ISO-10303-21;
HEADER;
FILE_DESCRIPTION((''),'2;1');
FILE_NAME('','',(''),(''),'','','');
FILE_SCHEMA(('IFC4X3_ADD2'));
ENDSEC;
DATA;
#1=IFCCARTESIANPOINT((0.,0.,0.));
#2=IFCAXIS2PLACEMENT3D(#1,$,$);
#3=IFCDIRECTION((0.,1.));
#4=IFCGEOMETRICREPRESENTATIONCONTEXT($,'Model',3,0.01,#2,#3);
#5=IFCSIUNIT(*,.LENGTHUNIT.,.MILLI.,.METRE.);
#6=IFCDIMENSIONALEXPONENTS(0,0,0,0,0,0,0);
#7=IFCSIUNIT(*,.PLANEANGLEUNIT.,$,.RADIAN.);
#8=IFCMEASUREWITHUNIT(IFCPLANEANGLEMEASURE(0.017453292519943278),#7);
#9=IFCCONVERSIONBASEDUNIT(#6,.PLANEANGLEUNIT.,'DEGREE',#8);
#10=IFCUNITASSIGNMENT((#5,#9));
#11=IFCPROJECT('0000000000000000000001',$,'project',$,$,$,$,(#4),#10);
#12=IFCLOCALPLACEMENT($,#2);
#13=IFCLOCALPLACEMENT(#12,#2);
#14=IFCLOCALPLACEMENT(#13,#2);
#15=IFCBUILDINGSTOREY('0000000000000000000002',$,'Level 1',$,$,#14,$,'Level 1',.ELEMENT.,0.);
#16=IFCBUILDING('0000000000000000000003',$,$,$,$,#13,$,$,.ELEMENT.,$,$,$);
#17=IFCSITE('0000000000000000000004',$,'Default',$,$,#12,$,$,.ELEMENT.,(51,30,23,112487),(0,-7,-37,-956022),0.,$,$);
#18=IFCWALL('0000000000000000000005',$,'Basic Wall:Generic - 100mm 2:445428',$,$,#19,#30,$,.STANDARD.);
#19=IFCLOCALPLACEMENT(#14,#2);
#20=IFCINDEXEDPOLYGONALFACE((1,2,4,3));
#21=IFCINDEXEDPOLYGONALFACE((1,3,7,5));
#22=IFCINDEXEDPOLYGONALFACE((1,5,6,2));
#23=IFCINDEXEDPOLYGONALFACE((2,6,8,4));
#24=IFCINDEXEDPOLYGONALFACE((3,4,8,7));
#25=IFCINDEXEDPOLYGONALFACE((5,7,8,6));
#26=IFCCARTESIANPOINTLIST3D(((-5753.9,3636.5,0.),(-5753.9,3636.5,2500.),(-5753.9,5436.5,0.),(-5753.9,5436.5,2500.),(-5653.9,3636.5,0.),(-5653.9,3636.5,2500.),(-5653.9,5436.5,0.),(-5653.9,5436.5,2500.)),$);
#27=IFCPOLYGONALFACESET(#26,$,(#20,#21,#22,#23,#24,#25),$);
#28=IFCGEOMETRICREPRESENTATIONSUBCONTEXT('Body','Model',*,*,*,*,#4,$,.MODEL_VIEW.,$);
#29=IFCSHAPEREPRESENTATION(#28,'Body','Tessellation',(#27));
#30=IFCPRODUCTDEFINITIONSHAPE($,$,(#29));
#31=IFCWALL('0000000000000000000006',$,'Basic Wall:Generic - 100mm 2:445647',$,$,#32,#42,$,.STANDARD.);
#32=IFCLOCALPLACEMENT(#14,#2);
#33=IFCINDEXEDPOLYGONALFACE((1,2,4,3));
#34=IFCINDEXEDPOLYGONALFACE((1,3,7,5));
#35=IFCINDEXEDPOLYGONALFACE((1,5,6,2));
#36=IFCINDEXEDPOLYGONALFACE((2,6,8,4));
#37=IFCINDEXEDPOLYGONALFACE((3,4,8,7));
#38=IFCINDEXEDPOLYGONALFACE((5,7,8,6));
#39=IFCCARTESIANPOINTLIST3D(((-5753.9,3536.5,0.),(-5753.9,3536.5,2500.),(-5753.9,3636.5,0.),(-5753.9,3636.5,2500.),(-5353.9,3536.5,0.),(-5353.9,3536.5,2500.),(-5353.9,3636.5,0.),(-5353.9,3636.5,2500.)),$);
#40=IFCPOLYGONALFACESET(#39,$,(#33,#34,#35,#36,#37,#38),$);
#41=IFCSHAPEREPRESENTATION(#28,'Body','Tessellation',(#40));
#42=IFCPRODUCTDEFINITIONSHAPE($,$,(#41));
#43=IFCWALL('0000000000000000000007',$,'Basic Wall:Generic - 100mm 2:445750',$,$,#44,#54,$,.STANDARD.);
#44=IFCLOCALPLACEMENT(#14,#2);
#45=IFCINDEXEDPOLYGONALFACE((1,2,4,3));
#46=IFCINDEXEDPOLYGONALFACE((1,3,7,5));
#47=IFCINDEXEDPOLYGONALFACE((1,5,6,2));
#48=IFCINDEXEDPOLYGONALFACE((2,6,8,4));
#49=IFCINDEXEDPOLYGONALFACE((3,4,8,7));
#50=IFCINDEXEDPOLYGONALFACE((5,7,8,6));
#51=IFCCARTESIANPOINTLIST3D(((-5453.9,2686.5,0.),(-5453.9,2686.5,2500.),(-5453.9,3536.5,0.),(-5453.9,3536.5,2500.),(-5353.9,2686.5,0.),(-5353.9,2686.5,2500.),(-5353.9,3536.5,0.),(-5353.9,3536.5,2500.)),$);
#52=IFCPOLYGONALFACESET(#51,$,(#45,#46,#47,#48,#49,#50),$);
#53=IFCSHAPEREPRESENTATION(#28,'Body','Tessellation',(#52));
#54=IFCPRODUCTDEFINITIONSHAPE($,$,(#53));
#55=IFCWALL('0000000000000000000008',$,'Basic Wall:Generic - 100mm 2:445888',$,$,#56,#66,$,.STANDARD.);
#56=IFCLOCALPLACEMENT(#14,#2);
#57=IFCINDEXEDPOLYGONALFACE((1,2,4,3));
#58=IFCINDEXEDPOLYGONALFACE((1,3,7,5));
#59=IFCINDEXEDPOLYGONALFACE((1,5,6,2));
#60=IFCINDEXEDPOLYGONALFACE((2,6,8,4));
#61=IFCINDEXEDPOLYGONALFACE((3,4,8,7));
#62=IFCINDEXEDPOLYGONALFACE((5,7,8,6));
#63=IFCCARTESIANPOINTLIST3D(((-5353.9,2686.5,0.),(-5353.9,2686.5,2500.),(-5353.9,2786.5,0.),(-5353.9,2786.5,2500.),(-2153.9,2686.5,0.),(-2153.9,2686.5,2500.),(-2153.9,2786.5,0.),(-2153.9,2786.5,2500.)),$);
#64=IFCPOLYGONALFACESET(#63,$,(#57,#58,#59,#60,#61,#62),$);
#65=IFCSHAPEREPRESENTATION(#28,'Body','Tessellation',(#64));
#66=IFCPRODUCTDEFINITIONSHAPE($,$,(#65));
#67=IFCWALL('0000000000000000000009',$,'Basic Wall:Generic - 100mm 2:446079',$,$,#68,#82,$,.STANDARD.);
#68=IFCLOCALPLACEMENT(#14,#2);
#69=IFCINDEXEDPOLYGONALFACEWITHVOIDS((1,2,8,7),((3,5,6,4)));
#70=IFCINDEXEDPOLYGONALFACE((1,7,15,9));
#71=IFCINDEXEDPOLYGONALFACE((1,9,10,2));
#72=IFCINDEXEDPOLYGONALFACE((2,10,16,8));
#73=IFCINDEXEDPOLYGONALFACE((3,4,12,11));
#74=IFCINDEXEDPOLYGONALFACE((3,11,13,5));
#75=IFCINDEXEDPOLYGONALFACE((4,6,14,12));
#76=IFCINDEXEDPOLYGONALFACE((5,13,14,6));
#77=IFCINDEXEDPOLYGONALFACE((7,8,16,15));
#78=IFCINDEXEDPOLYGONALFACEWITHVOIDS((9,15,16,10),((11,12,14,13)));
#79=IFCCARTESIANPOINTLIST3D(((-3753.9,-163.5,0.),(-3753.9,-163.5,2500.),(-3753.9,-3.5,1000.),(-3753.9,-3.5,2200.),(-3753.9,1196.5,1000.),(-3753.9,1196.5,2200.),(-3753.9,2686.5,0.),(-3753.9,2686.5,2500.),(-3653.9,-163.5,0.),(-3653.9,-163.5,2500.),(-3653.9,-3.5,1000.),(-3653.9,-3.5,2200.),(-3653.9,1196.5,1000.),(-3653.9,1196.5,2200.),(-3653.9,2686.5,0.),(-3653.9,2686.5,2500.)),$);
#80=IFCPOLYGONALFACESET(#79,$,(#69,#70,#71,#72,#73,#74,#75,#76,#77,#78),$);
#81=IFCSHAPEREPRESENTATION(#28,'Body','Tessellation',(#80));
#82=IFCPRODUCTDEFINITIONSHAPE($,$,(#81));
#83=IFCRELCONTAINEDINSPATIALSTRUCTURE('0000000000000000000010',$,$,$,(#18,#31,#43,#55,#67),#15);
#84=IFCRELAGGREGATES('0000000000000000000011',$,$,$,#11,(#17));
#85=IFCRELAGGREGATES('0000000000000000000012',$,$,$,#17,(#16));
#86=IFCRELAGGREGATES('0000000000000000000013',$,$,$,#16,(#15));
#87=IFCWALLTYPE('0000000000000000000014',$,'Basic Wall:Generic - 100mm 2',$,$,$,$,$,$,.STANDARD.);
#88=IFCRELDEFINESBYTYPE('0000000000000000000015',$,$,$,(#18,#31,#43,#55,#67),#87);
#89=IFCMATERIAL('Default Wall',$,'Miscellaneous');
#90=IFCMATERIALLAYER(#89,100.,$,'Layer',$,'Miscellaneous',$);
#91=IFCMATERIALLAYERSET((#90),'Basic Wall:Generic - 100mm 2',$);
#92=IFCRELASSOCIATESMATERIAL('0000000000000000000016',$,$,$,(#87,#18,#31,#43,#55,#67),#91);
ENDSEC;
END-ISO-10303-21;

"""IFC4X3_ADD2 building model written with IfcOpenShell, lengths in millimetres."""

from ifc_helpers import new_model, entity, si_unit, converted_unit, direction, frame, frame_2d, origin, place, context, subcontext, project, spatial, rectangle, extrude, material, layer, layer_set, type_object, element, save


model = new_model("IFC4X3_ADD2")

# Units and contexts
model_context = context("Model", 3, precision=0.01, world=origin(), true_north=direction((0.0, 1.0)))
body_context = subcontext(model_context, "Body", "Model", "MODEL_VIEW")
ifc_project = project(units=[si_unit("LENGTHUNIT", "METRE", prefix="MILLI"), converted_unit("PLANEANGLEUNIT", "DEGREE", entity("IfcPlaneAngleMeasure", 0.017453292519943278), si_unit("PLANEANGLEUNIT", "RADIAN"), dimensions=[0, 0, 0, 0, 0, 0, 0])], contexts=[model_context])

# Site, building, storey
site_placement = place(None, origin())
site = spatial("IfcSite", under=ifc_project, at=site_placement, Name="Default", CompositionType="ELEMENT", RefLatitude=(51, 30, 23, 112487), RefLongitude=(0, -7, -37, -956022), RefElevation=0.0)
building_placement = place(site_placement, origin())
building = spatial("IfcBuilding", under=site, at=building_placement, CompositionType="ELEMENT")
storey_placement = place(building_placement, origin())
storey = spatial("IfcBuildingStorey", under=building, at=storey_placement, Name="Level 1", LongName="Level 1", CompositionType="ELEMENT", Elevation=0.0)

# Shared definitions
ifc_material_1 = material(Name="Default Wall", Category="Miscellaneous")
ifc_layer_1 = layer(ifc_material_1, 100.0, Name="Layer", Category="Miscellaneous")
ifc_layer_set_1 = layer_set([ifc_layer_1], Name="Basic Wall:Generic - 100mm 2")
wall_type = type_object("IfcWallType", Name="Basic Wall:Generic - 100mm 2", PredefinedType="STANDARD", material=ifc_layer_set_1)

# Walls
wall_1_placement = place(storey_placement, frame((-5703.9, 5436.5, 0.0), z_axis=(0.0, 0.0, 1.0), x_axis=(0.0, -1.0, 0.0)))
element("IfcWall", 1, at=wall_1_placement, inside=storey, type_object=wall_type, material=ifc_layer_set_1, Name="Basic Wall:Generic - 100mm 2:445428", PredefinedType="STANDARD", context=body_context, shape_type="SweptSolid", body=[
    extrude(rectangle(XDim=1800.0, YDim=100.0, at=frame_2d((900.0, 0.0), x_axis=(-1.0, 0.0))), origin(), (0.0, 0.0, 1.0), 2500.0),
])
wall_2_placement = place(storey_placement, frame((-5753.9, 3586.5, 0.0)))
element("IfcWall", 2, at=wall_2_placement, inside=storey, type_object=wall_type, material=ifc_layer_set_1, Name="Basic Wall:Generic - 100mm 2:445647", PredefinedType="STANDARD", context=body_context, shape_type="SweptSolid", body=[
    extrude(rectangle(XDim=400.0, YDim=100.0, at=frame_2d((200.0, 0.0), x_axis=(-1.0, 0.0))), origin(), (0.0, 0.0, 1.0), 2500.0),
])
wall_3_placement = place(storey_placement, frame((-5403.9, 3536.5, 0.0), z_axis=(0.0, 0.0, 1.0), x_axis=(0.0, -1.0, 0.0)))
element("IfcWall", 3, at=wall_3_placement, inside=storey, type_object=wall_type, material=ifc_layer_set_1, Name="Basic Wall:Generic - 100mm 2:445750", PredefinedType="STANDARD", context=body_context, shape_type="SweptSolid", body=[
    extrude(rectangle(XDim=850.0, YDim=100.0, at=frame_2d((425.0, 0.0), x_axis=(-1.0, 0.0))), origin(), (0.0, 0.0, 1.0), 2500.0),
])
wall_4_placement = place(storey_placement, frame((-5353.9, 2736.5, 0.0)))
element("IfcWall", 4, at=wall_4_placement, inside=storey, type_object=wall_type, material=ifc_layer_set_1, Name="Basic Wall:Generic - 100mm 2:445888", PredefinedType="STANDARD", context=body_context, shape_type="SweptSolid", body=[
    extrude(rectangle(XDim=3200.0, YDim=100.0, at=frame_2d((1600.0, 0.0), x_axis=(-1.0, 0.0))), origin(), (0.0, 0.0, 1.0), 2500.0),
])

# Wall, opening
wall_5_placement = place(storey_placement, frame((-3703.9, 2686.5, 0.0), z_axis=(0.0, 0.0, 1.0), x_axis=(0.0, -1.0, 0.0)))
wall_5 = element("IfcWall", 5, at=wall_5_placement, inside=storey, type_object=wall_type, material=ifc_layer_set_1, Name="Basic Wall:Generic - 100mm 2:446079", PredefinedType="STANDARD", context=body_context, shape_type="SweptSolid", body=[
    extrude(rectangle(XDim=2850.0, YDim=100.0, at=frame_2d((1425.0, 0.0), x_axis=(-1.0, 0.0))), origin(), (0.0, 0.0, 1.0), 2500.0),
])
opening_1_placement = place(wall_5_placement, frame((1490.0, -50.0, 1000.0)))
element("IfcOpeningElement", 6, at=opening_1_placement, cuts=wall_5, PredefinedType="OPENING", context=body_context, shape_type="SweptSolid", body=[
    extrude(rectangle(XDim=1200.0, YDim=1200.0, at=frame_2d((600.0, 600.0), x_axis=(-1.0, 0.0))), frame((0.0, 0.0, 0.0), z_axis=(0.0, 1.0, 0.0), x_axis=(0.0, 0.0, 1.0)), (0.0, 0.0, 1.0), 100.0),
])

save(model, "model.ifc")
